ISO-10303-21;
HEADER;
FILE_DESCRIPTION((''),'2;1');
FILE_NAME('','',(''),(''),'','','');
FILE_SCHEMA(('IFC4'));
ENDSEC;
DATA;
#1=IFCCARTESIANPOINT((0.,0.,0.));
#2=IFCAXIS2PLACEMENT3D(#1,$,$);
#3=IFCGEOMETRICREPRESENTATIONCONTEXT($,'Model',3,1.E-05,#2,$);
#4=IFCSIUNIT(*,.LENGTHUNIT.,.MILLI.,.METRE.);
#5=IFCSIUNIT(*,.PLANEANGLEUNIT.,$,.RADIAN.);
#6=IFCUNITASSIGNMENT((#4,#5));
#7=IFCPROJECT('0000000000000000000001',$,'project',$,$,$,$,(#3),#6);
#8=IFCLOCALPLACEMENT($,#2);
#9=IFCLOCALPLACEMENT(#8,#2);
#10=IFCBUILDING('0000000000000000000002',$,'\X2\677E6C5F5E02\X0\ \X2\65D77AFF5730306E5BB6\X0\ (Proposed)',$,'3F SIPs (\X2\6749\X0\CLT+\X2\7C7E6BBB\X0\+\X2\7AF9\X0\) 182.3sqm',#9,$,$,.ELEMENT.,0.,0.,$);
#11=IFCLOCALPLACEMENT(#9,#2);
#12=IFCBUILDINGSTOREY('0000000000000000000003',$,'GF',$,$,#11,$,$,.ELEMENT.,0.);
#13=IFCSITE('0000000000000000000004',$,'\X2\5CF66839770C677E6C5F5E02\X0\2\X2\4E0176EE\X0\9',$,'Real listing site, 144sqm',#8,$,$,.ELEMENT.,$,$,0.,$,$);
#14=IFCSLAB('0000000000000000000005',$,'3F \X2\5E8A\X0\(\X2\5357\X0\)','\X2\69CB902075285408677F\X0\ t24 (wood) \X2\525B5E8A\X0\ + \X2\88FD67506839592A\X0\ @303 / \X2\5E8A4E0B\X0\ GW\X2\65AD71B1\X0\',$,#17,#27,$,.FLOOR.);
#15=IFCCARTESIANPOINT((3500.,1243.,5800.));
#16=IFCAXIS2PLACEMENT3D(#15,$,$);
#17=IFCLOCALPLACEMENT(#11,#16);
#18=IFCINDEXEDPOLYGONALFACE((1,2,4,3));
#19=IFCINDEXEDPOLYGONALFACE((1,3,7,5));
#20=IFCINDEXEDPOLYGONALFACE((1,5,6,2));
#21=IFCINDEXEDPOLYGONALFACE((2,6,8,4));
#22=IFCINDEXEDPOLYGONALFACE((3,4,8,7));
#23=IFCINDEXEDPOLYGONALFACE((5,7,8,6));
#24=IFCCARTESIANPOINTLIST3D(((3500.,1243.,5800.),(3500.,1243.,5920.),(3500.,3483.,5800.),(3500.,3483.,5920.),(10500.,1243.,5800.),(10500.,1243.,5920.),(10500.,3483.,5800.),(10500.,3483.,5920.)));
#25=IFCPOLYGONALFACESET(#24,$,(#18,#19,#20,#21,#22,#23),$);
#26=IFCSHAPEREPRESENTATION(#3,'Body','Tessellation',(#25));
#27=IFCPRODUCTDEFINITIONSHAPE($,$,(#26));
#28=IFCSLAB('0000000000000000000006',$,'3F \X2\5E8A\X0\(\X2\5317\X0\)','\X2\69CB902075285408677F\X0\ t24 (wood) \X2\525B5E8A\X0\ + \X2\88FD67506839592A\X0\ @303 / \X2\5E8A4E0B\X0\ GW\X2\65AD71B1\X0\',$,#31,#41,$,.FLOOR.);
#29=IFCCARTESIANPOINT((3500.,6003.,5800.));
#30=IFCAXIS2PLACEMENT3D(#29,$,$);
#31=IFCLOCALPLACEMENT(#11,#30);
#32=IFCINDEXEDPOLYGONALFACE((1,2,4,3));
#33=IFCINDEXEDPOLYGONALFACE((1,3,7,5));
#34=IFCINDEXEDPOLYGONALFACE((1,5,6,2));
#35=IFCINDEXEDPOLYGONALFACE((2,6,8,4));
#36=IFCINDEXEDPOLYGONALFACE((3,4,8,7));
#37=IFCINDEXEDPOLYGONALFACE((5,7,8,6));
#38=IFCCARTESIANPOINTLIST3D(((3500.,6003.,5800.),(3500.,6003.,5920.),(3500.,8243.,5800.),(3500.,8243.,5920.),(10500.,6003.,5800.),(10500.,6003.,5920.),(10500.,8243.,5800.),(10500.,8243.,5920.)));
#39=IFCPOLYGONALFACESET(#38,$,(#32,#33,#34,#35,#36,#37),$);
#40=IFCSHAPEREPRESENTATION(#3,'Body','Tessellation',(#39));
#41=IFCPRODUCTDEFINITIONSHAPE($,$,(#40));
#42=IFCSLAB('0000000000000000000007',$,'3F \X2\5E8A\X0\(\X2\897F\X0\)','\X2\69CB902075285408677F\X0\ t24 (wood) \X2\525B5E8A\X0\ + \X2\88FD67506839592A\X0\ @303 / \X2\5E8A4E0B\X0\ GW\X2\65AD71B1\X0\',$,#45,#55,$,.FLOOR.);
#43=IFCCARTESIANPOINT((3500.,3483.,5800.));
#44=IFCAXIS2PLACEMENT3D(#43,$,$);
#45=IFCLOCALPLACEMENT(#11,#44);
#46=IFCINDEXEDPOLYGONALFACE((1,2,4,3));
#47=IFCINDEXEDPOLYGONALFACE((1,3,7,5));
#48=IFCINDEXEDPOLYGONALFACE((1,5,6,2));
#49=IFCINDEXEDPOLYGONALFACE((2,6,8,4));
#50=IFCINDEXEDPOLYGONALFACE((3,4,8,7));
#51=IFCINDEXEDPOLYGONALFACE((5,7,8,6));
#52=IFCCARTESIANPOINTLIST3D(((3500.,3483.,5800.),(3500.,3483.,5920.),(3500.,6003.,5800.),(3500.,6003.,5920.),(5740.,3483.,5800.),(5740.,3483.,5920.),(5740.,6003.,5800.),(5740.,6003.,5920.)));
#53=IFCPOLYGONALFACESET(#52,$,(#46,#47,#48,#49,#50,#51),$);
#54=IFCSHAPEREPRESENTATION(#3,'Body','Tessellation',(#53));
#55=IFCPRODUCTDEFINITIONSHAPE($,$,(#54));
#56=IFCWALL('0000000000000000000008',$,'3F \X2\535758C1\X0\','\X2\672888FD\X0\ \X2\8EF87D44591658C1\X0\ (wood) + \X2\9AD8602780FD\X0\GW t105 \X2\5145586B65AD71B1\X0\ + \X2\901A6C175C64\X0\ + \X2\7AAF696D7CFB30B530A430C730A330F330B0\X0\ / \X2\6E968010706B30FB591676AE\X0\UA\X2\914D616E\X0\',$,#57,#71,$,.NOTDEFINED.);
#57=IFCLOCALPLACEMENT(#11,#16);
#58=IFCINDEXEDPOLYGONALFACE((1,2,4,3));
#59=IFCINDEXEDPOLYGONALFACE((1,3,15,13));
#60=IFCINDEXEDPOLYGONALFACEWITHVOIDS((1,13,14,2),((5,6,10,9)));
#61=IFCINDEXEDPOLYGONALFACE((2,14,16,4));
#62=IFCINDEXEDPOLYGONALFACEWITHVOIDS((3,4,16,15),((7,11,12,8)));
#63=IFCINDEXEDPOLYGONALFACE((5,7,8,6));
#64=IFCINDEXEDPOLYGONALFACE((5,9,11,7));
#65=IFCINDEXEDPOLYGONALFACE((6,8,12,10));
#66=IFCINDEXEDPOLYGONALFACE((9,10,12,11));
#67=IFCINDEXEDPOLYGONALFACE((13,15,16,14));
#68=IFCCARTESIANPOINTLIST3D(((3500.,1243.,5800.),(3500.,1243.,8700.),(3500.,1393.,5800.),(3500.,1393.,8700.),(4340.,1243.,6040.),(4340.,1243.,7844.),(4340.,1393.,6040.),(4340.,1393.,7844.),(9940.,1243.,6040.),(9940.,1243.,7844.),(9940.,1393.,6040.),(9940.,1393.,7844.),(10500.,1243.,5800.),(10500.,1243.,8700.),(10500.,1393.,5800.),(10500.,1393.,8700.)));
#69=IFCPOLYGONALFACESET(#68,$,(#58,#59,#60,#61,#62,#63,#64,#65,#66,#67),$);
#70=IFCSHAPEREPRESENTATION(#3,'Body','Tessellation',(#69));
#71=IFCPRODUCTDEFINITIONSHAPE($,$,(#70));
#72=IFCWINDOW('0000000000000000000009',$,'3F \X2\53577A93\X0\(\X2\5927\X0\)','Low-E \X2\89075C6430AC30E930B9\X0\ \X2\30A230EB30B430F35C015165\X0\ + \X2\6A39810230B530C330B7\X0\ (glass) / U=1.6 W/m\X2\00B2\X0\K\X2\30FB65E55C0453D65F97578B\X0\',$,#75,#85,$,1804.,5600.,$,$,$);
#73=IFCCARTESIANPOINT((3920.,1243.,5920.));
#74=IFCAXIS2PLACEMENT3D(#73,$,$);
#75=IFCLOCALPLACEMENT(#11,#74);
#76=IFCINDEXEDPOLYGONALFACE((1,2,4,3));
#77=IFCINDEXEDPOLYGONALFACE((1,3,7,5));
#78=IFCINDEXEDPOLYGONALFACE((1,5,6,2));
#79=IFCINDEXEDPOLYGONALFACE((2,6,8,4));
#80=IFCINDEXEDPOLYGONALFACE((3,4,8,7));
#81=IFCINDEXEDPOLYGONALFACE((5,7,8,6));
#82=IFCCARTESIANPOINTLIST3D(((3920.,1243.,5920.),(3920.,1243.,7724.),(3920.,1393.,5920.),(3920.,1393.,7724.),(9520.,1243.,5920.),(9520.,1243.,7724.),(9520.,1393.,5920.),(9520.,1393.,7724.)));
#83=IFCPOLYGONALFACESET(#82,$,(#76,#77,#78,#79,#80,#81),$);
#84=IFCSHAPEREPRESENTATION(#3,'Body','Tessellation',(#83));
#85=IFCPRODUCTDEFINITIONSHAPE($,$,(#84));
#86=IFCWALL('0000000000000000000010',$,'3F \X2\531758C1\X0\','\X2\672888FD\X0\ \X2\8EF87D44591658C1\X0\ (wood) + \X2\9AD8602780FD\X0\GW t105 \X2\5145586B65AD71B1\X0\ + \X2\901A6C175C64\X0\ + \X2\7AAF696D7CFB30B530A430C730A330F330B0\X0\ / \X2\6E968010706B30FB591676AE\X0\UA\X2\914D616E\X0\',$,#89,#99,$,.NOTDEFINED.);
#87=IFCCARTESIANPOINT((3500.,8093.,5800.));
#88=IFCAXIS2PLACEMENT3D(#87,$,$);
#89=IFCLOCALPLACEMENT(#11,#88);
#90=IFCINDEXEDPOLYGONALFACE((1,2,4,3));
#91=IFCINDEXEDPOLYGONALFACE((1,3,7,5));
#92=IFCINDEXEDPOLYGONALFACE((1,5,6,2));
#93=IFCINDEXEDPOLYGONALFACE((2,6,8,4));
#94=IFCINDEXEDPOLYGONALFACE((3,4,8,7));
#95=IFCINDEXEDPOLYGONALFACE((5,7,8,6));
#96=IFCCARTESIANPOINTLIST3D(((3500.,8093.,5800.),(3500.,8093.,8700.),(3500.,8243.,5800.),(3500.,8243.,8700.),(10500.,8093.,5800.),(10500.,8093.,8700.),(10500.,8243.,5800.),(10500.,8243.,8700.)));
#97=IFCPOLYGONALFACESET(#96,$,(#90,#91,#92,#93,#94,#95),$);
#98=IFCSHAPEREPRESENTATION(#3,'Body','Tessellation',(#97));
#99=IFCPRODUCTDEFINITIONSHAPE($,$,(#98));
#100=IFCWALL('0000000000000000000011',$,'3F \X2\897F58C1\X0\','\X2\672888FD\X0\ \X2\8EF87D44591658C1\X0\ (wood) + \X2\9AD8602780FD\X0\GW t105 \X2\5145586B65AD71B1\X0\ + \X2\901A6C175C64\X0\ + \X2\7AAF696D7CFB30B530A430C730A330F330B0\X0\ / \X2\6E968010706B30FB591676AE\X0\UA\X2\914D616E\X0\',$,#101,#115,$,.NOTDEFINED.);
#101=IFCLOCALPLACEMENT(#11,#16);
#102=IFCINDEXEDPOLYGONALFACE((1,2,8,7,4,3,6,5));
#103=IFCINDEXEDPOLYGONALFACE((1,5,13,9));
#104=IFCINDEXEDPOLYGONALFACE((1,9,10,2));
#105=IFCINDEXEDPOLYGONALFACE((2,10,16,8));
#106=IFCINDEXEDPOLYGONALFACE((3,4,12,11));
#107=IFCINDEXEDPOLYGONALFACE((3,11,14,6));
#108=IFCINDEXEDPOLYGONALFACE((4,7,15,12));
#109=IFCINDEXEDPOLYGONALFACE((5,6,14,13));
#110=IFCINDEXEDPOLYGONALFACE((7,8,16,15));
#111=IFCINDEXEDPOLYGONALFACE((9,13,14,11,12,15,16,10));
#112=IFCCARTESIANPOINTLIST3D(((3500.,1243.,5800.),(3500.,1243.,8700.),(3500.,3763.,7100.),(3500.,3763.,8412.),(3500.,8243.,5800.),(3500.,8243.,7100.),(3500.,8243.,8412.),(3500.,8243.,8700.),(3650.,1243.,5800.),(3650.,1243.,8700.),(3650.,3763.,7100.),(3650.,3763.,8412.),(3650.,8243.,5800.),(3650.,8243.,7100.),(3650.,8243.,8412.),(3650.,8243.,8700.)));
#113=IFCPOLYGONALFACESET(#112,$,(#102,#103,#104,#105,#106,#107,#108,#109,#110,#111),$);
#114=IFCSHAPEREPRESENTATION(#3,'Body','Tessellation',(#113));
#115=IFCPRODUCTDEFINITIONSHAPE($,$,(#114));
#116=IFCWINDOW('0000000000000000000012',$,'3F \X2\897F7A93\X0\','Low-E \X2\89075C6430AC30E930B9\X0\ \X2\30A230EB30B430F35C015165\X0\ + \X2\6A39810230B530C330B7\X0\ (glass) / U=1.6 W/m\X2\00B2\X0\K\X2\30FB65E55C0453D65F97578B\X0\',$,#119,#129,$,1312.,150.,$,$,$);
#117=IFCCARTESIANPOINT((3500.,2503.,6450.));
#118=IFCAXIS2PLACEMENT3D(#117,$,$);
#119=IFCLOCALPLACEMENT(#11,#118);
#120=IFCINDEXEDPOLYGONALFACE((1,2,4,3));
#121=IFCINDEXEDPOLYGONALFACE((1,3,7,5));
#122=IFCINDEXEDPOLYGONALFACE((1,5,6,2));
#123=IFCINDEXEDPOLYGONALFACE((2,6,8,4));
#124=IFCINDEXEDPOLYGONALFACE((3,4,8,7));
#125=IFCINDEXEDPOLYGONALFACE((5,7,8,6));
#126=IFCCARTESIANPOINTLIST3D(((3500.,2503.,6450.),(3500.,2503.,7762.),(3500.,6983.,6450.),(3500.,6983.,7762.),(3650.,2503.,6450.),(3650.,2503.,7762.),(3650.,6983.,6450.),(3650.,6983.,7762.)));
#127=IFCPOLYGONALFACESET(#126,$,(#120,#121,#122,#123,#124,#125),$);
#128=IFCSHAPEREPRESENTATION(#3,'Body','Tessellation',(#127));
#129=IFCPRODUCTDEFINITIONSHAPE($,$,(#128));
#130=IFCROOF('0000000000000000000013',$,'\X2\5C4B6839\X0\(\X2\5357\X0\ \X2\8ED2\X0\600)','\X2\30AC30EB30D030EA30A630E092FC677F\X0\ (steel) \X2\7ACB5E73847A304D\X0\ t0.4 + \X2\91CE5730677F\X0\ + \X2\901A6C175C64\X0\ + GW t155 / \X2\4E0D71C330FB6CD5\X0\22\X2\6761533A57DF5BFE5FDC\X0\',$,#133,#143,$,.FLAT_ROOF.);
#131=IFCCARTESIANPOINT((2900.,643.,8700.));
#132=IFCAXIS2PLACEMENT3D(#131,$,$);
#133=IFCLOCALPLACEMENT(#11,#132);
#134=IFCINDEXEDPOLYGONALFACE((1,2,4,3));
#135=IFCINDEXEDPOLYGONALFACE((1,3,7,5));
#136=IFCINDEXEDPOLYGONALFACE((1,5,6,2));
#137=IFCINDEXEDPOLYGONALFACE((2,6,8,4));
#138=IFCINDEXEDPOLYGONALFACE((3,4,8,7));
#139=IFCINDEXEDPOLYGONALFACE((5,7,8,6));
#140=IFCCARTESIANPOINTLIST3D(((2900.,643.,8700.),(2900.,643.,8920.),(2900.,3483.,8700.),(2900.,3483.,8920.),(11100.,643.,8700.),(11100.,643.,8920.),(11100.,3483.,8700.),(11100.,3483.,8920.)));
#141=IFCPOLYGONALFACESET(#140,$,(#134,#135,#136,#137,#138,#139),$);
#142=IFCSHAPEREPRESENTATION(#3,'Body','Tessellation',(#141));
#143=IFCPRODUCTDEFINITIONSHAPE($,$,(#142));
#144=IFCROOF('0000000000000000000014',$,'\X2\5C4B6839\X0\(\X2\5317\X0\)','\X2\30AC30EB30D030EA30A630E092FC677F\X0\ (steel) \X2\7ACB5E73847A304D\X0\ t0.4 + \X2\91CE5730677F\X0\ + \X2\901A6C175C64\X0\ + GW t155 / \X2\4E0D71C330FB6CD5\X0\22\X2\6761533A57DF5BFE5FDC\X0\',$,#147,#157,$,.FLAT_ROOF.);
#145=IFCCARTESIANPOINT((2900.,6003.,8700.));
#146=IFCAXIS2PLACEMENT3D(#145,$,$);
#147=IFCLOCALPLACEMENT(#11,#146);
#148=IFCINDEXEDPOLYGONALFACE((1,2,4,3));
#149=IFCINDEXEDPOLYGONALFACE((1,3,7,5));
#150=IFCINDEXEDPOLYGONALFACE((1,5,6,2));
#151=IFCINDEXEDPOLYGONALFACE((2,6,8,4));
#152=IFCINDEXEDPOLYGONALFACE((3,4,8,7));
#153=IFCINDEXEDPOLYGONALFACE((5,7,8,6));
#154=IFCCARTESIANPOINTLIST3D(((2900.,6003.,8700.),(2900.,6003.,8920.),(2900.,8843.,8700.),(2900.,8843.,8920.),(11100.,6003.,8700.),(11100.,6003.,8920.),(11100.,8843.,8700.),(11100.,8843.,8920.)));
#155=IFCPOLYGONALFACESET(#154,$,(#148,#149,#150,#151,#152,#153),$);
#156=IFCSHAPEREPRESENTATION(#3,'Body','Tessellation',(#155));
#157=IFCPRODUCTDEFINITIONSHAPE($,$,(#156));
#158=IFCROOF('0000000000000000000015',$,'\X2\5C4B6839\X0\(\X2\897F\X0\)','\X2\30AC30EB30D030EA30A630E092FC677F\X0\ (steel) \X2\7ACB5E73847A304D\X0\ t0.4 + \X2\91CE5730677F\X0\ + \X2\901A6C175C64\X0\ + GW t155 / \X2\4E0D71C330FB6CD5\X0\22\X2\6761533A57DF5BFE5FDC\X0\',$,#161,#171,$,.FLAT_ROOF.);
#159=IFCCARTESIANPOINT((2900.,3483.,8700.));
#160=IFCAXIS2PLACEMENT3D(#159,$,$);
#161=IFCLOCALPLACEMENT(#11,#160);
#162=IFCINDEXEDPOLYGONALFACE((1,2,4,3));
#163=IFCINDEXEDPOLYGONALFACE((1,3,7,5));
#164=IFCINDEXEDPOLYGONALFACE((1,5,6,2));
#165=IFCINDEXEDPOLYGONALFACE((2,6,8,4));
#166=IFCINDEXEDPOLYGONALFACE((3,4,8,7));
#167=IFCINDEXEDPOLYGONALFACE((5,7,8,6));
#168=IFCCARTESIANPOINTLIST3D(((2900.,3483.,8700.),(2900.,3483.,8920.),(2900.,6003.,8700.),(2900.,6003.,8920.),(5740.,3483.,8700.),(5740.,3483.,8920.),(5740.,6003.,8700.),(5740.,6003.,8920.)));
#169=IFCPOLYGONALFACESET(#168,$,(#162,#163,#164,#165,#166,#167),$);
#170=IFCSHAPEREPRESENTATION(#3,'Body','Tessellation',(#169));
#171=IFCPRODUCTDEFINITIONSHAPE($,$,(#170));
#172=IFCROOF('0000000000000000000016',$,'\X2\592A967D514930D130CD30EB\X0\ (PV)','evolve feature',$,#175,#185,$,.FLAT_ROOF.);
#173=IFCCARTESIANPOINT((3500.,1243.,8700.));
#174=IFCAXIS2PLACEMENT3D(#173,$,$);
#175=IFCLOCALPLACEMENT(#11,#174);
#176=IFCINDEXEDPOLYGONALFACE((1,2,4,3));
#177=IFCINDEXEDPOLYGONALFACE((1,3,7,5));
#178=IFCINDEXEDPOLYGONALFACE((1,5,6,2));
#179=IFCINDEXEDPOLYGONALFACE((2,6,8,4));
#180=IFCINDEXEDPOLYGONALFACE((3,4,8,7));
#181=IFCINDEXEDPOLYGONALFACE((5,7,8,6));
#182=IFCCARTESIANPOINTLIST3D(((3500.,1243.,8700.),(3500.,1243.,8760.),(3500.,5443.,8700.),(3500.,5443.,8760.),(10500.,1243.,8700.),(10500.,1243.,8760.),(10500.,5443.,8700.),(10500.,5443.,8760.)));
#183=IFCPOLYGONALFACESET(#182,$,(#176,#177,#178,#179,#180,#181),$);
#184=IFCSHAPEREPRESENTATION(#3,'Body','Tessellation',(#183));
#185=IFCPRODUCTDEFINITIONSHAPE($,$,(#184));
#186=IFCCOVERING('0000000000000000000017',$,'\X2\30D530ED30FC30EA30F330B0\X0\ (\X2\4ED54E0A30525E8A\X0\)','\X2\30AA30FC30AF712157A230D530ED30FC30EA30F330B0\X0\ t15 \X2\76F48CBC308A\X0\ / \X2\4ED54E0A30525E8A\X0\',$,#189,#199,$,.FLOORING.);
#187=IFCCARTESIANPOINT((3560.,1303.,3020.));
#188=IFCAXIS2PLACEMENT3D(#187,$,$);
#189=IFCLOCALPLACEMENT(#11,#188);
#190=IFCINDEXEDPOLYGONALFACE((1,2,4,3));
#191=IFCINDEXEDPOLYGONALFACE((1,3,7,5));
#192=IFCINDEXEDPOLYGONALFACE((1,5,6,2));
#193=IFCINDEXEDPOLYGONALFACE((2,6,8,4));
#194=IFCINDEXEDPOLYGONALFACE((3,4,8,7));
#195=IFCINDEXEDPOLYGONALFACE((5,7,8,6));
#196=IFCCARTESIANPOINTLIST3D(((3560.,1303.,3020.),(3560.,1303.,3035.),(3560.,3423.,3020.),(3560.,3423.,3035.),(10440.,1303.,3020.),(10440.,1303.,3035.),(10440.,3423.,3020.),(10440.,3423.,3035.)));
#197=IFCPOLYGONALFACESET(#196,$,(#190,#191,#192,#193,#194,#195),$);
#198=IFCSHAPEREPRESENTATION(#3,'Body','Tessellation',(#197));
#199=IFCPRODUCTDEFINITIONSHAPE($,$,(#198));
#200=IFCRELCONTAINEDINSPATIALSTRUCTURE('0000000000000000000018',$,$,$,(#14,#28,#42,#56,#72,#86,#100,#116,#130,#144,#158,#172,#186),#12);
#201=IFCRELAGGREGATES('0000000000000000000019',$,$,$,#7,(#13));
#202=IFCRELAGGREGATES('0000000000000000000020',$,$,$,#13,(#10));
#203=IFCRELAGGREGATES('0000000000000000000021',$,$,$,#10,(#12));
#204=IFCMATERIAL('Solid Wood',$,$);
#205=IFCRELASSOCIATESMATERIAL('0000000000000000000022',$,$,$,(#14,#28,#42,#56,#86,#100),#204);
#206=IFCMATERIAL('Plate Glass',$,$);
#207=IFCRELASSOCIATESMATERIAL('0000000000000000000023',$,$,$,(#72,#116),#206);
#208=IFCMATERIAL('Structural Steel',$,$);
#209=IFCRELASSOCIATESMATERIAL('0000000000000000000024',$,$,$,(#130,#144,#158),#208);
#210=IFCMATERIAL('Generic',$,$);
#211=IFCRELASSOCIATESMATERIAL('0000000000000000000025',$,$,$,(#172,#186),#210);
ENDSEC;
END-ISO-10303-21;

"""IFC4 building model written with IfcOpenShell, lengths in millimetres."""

from ifc_helpers import new_model, si_unit, frame, frame_2d, origin, place, context, project, spatial, rectangle, extrude, material, element, fill, save


model = new_model("IFC4")

# Units and contexts
model_context = context("Model", 3, precision=1e-05, world=origin())
ifc_project = project(units=[si_unit("LENGTHUNIT", "METRE", prefix="MILLI"), si_unit("PLANEANGLEUNIT", "RADIAN")], contexts=[model_context])

# Site, building, storey
site_placement = place(None, origin())
site = spatial("IfcSite", under=ifc_project, at=site_placement, Name="島根県松江市2丁目9", ObjectType="Real listing site, 144sqm", CompositionType="ELEMENT", RefElevation=0.0)
building_placement = place(site_placement, origin())
building = spatial("IfcBuilding", under=site, at=building_placement, Name="松江市 旗竿地の家 (Proposed)", ObjectType="3F SIPs (杉CLT+籾殻+竹) 182.3sqm", CompositionType="ELEMENT", ElevationOfRefHeight=0.0, ElevationOfTerrain=0.0)
storey_placement = place(building_placement, origin())
storey = spatial("IfcBuildingStorey", under=building, at=storey_placement, Name="GF", CompositionType="ELEMENT", Elevation=0.0)

# Slabs
ifc_material_1 = material(Name="Solid Wood")
slab_1_placement = place(storey_placement, frame((3500.0, 1243.0, 5800.0)))
element("IfcSlab", 1, at=slab_1_placement, inside=storey, material=ifc_material_1, Name="3F 床(南)", Description="構造用合板 t24 (wood) 剛床 + 製材根太 @303 / 床下 GW断熱", PredefinedType="FLOOR", context=model_context, shape_type="SweptSolid", body=[
    extrude(rectangle(XDim=7000.0, YDim=2240.0, at=frame_2d((3500.0, 1120.0))), frame((3500.0, 1243.0, 5800.0)), (0.0, 0.0, 1.0), 120.0),
])
slab_2_placement = place(storey_placement, frame((3500.0, 6003.0, 5800.0)))
element("IfcSlab", 2, at=slab_2_placement, inside=storey, material=ifc_material_1, Name="3F 床(北)", Description="構造用合板 t24 (wood) 剛床 + 製材根太 @303 / 床下 GW断熱", PredefinedType="FLOOR", context=model_context, shape_type="SweptSolid", body=[
    extrude(rectangle(XDim=7000.0, YDim=2240.0, at=frame_2d((3500.0, 1120.0))), frame((3500.0, 6003.0, 5800.0)), (0.0, 0.0, 1.0), 120.0),
])
slab_3_placement = place(storey_placement, frame((3500.0, 3483.0, 5800.0)))
element("IfcSlab", 3, at=slab_3_placement, inside=storey, material=ifc_material_1, Name="3F 床(西)", Description="構造用合板 t24 (wood) 剛床 + 製材根太 @303 / 床下 GW断熱", PredefinedType="FLOOR", context=model_context, shape_type="SweptSolid", body=[
    extrude(rectangle(XDim=2240.0, YDim=2520.0, at=frame_2d((1120.0, 1260.0))), frame((3500.0, 3483.0, 5800.0)), (0.0, 0.0, 1.0), 120.0),
])

# Wall, opening, window
wall_1_placement = place(storey_placement, frame((3500.0, 1243.0, 5800.0)))
wall_1 = element("IfcWall", 4, at=wall_1_placement, inside=storey, material=ifc_material_1, Name="3F 南壁", Description="木製 軸組外壁 (wood) + 高性能GW t105 充填断熱 + 通気層 + 窯業系サイディング / 準耐火・外皮UA配慮", PredefinedType="NOTDEFINED", context=model_context, shape_type="SweptSolid", body=[
    extrude(rectangle(XDim=7000.0, YDim=150.0, at=frame_2d((3500.0, 75.0))), frame((3500.0, 1243.0, 5800.0)), (0.0, 0.0, 1.0), 2900.0),
])
opening_1_placement = place(storey_placement, frame((3920.0, 1243.0, 5920.0)))
opening_1 = element("IfcOpeningElement", 5, at=opening_1_placement, cuts=wall_1, PredefinedType="NOTDEFINED", context=model_context, shape_type="SweptSolid", body=[
    extrude(rectangle(XDim=5600.0, YDim=150.0, at=frame_2d((2800.0, 75.0))), frame((3920.0, 1243.0, 5920.0)), (0.0, 0.0, 1.0), 1804.0),
])
ifc_material_2 = material(Name="Plate Glass")
window_1_placement = place(storey_placement, frame((3920.0, 1243.0, 5920.0)))
window_1 = element("IfcWindow", 6, at=window_1_placement, inside=storey, material=ifc_material_2, Name="3F 南窓(大)", Description="Low-E 複層ガラス アルゴン封入 + 樹脂サッシ (glass) / U=1.6 W/m²K・日射取得型", OverallHeight=1804.0, OverallWidth=5600.0, context=model_context, shape_type="SweptSolid", body=[
    extrude(rectangle(XDim=5600.0, YDim=150.0, at=frame_2d((2800.0, 75.0))), frame((3920.0, 1243.0, 5920.0)), (0.0, 0.0, 1.0), 1804.0),
])
fill(opening_1, window_1)

# Wall
wall_2_placement = place(storey_placement, frame((3500.0, 8093.0, 5800.0)))
element("IfcWall", 7, at=wall_2_placement, inside=storey, material=ifc_material_1, Name="3F 北壁", Description="木製 軸組外壁 (wood) + 高性能GW t105 充填断熱 + 通気層 + 窯業系サイディング / 準耐火・外皮UA配慮", PredefinedType="NOTDEFINED", context=model_context, shape_type="SweptSolid", body=[
    extrude(rectangle(XDim=7000.0, YDim=150.0, at=frame_2d((3500.0, 75.0))), frame((3500.0, 8093.0, 5800.0)), (0.0, 0.0, 1.0), 2900.0),
])

# Wall, opening, window
wall_3_placement = place(storey_placement, frame((3500.0, 1243.0, 5800.0)))
wall_3 = element("IfcWall", 8, at=wall_3_placement, inside=storey, material=ifc_material_1, Name="3F 西壁", Description="木製 軸組外壁 (wood) + 高性能GW t105 充填断熱 + 通気層 + 窯業系サイディング / 準耐火・外皮UA配慮", PredefinedType="NOTDEFINED", context=model_context, shape_type="SweptSolid", body=[
    extrude(rectangle(XDim=150.0, YDim=7000.0, at=frame_2d((75.0, 3500.0))), frame((3500.0, 1243.0, 5800.0)), (0.0, 0.0, 1.0), 2900.0),
])
opening_2_placement = place(storey_placement, frame((3500.0, 2503.0, 6450.0)))
opening_2 = element("IfcOpeningElement", 9, at=opening_2_placement, cuts=wall_3, PredefinedType="NOTDEFINED", context=model_context, shape_type="SweptSolid", body=[
    extrude(rectangle(XDim=150.0, YDim=4480.0, at=frame_2d((75.0, 2240.0))), frame((3500.0, 2503.0, 6450.0)), (0.0, 0.0, 1.0), 1312.0),
])
window_2_placement = place(storey_placement, frame((3500.0, 2503.0, 6450.0)))
window_2 = element("IfcWindow", 10, at=window_2_placement, inside=storey, material=ifc_material_2, Name="3F 西窓", Description="Low-E 複層ガラス アルゴン封入 + 樹脂サッシ (glass) / U=1.6 W/m²K・日射取得型", OverallHeight=1312.0, OverallWidth=150.0, context=model_context, shape_type="SweptSolid", body=[
    extrude(rectangle(XDim=150.0, YDim=4480.0, at=frame_2d((75.0, 2240.0))), frame((3500.0, 2503.0, 6450.0)), (0.0, 0.0, 1.0), 1312.0),
])
fill(opening_2, window_2)

# Roofs
ifc_material_3 = material(Name="Structural Steel")
roof_1_placement = place(storey_placement, frame((2900.0, 643.0, 8700.0)))
element("IfcRoof", 11, at=roof_1_placement, inside=storey, material=ifc_material_3, Name="屋根(南 軒600)", Description="ガルバリウム鋼板 (steel) 立平葺き t0.4 + 野地板 + 通気層 + GW t155 / 不燃・法22条区域対応", PredefinedType="FLAT_ROOF", context=model_context, shape_type="SweptSolid", body=[
    extrude(rectangle(XDim=8200.0, YDim=2840.0, at=frame_2d((4100.0, 1420.0))), frame((2900.0, 643.0, 8700.0)), (0.0, 0.0, 1.0), 220.0),
])
roof_2_placement = place(storey_placement, frame((2900.0, 6003.0, 8700.0)))
element("IfcRoof", 12, at=roof_2_placement, inside=storey, material=ifc_material_3, Name="屋根(北)", Description="ガルバリウム鋼板 (steel) 立平葺き t0.4 + 野地板 + 通気層 + GW t155 / 不燃・法22条区域対応", PredefinedType="FLAT_ROOF", context=model_context, shape_type="SweptSolid", body=[
    extrude(rectangle(XDim=8200.0, YDim=2840.0, at=frame_2d((4100.0, 1420.0))), frame((2900.0, 6003.0, 8700.0)), (0.0, 0.0, 1.0), 220.0),
])
roof_3_placement = place(storey_placement, frame((2900.0, 3483.0, 8700.0)))
element("IfcRoof", 13, at=roof_3_placement, inside=storey, material=ifc_material_3, Name="屋根(西)", Description="ガルバリウム鋼板 (steel) 立平葺き t0.4 + 野地板 + 通気層 + GW t155 / 不燃・法22条区域対応", PredefinedType="FLAT_ROOF", context=model_context, shape_type="SweptSolid", body=[
    extrude(rectangle(XDim=2840.0, YDim=2520.0, at=frame_2d((1420.0, 1260.0))), frame((2900.0, 3483.0, 8700.0)), (0.0, 0.0, 1.0), 220.0),
])
ifc_material_4 = material(Name="Generic")
roof_4_placement = place(storey_placement, frame((3500.0, 1243.0, 8700.0)))
element("IfcRoof", 14, at=roof_4_placement, inside=storey, material=ifc_material_4, Name="太陽光パネル (PV)", Description="evolve feature", PredefinedType="FLAT_ROOF", context=model_context, shape_type="SweptSolid", body=[
    extrude(rectangle(XDim=7000.0, YDim=4200.0, at=frame_2d((3500.0, 2100.0))), frame((3500.0, 1243.0, 8700.0)), (0.0, 0.0, 1.0), 60.0),
])

# Covering
covering_1_placement = place(storey_placement, frame((3560.0, 1303.0, 3020.0)))
element("IfcCovering", 15, at=covering_1_placement, inside=storey, material=ifc_material_4, Name="フローリング (仕上げ床)", Description="オーク無垢フローリング t15 直貼り / 仕上げ床", PredefinedType="FLOORING", context=model_context, shape_type="SweptSolid", body=[
    extrude(rectangle(XDim=6880.0, YDim=2120.0, at=frame_2d((3440.0, 1060.0))), frame((3560.0, 1303.0, 3020.0)), (0.0, 0.0, 1.0), 15.0),
])

save(model, "model.ifc")
